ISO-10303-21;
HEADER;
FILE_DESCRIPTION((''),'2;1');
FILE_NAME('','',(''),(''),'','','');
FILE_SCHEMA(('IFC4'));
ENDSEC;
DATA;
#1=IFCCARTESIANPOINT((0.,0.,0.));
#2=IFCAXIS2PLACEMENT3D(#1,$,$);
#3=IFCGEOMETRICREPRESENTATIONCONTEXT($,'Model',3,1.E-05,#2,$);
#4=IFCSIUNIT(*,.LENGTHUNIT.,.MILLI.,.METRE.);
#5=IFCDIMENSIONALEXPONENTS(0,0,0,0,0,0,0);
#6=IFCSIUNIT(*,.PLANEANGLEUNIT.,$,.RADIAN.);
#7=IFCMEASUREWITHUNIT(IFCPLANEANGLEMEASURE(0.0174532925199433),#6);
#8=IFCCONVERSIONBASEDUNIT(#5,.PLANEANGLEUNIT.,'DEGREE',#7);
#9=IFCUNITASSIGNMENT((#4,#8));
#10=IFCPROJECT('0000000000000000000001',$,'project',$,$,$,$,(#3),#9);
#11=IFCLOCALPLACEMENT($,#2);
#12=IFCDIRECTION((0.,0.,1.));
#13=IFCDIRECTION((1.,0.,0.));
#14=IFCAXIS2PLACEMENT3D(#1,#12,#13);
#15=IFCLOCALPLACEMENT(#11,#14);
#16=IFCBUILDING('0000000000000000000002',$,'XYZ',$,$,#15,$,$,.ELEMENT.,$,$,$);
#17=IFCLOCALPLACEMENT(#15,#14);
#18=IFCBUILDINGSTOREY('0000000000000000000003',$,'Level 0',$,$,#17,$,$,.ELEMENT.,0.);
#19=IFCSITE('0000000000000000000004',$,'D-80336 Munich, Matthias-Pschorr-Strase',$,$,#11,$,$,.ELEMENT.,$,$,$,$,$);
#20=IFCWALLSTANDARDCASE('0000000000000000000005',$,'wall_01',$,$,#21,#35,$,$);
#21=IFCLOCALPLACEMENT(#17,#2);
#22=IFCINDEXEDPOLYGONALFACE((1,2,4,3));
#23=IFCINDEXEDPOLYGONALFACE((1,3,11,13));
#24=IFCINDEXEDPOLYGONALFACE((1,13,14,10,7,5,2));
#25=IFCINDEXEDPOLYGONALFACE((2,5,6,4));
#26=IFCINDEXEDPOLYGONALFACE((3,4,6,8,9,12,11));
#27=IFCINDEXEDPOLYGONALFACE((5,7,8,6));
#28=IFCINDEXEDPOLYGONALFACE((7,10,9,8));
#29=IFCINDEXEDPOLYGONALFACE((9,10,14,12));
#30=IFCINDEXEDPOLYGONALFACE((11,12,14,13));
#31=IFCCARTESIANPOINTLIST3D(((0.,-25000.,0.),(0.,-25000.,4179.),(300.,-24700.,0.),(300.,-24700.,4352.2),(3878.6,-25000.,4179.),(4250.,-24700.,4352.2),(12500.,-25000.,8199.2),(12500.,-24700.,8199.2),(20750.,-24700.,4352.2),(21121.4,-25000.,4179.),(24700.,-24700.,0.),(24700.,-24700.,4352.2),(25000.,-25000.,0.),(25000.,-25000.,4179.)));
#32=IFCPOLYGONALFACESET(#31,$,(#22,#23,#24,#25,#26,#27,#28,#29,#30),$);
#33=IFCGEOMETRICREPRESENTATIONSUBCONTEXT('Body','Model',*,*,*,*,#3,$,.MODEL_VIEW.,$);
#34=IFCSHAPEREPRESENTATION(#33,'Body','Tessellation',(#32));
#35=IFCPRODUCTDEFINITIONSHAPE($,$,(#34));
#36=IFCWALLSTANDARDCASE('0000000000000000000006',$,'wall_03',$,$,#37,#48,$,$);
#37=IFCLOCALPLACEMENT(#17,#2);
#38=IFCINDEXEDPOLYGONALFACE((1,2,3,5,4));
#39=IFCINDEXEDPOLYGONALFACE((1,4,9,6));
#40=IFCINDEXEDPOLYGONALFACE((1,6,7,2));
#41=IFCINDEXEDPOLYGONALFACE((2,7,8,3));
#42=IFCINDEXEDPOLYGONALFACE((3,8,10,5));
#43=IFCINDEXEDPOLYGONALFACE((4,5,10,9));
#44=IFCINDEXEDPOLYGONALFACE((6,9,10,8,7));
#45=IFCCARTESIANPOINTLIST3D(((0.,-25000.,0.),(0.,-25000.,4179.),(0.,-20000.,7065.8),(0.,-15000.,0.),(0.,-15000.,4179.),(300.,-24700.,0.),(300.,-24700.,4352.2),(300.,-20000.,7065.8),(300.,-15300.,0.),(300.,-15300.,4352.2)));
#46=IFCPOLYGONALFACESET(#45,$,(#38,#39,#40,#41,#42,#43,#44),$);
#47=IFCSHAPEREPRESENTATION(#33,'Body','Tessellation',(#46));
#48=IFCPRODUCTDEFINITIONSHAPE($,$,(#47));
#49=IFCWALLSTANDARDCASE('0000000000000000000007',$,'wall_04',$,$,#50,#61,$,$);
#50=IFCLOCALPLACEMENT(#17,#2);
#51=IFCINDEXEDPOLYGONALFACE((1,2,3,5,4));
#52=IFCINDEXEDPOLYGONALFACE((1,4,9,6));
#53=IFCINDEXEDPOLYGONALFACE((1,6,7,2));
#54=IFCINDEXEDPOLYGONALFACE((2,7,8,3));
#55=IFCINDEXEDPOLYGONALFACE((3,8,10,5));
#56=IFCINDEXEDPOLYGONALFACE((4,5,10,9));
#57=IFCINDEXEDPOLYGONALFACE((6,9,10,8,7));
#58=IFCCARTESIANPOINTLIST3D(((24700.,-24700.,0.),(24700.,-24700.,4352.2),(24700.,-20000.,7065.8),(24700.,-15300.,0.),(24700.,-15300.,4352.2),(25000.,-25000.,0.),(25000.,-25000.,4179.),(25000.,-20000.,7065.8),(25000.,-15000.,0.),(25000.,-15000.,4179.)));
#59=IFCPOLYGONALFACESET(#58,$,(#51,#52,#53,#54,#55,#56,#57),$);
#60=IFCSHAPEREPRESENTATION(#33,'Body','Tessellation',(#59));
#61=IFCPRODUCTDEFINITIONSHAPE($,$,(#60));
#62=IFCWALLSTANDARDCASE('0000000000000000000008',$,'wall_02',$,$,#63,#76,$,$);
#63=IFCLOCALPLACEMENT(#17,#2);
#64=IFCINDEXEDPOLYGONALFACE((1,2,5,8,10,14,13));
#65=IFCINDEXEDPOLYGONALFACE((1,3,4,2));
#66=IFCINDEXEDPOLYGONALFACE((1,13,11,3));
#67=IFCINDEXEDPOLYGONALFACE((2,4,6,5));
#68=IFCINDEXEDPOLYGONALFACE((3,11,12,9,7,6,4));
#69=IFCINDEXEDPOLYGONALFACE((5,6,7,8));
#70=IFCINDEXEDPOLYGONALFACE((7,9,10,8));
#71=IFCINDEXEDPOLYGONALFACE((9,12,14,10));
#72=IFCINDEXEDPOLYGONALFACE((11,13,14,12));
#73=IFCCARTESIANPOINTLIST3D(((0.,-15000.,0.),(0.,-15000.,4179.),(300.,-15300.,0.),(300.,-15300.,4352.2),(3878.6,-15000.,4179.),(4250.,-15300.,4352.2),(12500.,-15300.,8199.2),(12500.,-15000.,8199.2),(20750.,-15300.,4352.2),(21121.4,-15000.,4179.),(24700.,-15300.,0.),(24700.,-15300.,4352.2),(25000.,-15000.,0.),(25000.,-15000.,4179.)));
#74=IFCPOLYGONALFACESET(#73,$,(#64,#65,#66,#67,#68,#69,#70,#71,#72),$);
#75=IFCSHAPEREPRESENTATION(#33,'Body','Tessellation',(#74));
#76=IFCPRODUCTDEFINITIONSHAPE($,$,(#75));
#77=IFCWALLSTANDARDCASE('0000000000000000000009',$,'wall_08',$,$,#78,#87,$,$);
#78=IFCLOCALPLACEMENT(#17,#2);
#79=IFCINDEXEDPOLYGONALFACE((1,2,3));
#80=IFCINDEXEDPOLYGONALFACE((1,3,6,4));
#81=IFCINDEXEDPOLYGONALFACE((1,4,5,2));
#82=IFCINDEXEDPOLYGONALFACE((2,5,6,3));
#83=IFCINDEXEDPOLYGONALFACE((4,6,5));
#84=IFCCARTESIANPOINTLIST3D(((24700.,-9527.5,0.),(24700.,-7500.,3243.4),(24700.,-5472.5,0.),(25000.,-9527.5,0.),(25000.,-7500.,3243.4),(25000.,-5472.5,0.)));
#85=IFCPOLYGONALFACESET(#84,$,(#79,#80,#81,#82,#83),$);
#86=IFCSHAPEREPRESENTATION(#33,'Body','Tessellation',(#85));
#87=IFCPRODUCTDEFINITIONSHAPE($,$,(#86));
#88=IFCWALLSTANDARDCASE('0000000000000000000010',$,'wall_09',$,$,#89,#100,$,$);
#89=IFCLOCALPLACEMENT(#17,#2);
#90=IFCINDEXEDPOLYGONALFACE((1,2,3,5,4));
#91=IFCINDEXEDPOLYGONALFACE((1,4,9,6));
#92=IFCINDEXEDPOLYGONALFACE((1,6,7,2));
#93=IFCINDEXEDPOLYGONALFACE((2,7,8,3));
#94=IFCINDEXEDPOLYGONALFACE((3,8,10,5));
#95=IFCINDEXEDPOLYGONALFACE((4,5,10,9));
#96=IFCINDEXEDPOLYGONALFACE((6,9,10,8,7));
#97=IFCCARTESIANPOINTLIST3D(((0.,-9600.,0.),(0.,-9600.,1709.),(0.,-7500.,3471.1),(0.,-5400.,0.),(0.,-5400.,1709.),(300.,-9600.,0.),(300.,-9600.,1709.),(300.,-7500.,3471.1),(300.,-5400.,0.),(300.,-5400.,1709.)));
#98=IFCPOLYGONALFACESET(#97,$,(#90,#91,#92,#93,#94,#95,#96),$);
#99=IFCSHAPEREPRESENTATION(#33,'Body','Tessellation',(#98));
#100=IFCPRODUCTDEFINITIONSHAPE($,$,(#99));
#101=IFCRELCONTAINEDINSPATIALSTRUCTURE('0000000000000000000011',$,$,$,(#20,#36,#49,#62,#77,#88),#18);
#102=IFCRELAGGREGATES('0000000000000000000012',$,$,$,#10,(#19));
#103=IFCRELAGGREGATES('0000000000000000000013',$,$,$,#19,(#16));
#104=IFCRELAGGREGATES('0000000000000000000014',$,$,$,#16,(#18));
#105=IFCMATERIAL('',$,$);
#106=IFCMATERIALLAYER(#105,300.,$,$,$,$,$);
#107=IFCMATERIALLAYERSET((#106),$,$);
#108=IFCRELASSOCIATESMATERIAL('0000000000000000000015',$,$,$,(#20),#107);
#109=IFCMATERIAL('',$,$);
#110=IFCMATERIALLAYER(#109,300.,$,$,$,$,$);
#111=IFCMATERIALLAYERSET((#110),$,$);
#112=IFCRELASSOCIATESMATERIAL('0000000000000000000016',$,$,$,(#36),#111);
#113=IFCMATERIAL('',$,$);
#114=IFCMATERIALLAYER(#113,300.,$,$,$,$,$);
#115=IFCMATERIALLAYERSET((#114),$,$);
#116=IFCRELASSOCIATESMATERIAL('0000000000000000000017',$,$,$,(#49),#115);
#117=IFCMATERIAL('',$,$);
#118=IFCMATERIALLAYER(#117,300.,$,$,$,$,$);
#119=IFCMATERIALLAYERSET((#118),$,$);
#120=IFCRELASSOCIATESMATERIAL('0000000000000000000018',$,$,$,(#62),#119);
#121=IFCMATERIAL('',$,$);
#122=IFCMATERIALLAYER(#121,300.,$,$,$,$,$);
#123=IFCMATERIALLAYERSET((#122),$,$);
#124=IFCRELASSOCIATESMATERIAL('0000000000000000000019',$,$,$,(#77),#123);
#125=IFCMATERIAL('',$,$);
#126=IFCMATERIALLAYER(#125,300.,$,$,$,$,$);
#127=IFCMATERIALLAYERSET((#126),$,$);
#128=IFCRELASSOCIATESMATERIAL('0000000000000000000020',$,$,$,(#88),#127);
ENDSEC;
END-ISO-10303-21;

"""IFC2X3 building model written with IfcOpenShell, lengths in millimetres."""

from ifc_helpers import new_model, entity, si_unit, converted_unit, frame, frame_2d, origin, origin_with_axes, place, context, subcontext, project, spatial, polyline, rectangle, outline, extrude, clip, bounded_halfspace, material, layer, layer_set, layer_usage, element, save


model = new_model("IFC2X3")

# Units and contexts
model_context = context("Model", 3, precision=1e-05, world=origin())
body_context = subcontext(model_context, "Body", "Model", "MODEL_VIEW")
ifc_project = project(units=[si_unit("LENGTHUNIT", "METRE", prefix="MILLI"), converted_unit("PLANEANGLEUNIT", "DEGREE", entity("IfcPlaneAngleMeasure", 0.0174532925199433), si_unit("PLANEANGLEUNIT", "RADIAN"), dimensions=[0, 0, 0, 0, 0, 0, 0])], contexts=[model_context])

# Site, building, storey
site_placement = place(None, origin())
site = spatial("IfcSite", under=ifc_project, at=site_placement, Name="D-80336 Munich, Matthias-Pschorr-Strase", CompositionType="ELEMENT")
building_placement = place(site_placement, origin_with_axes())
building = spatial("IfcBuilding", under=site, at=building_placement, Name="XYZ", CompositionType="ELEMENT")
storey_placement = place(building_placement, origin_with_axes())
storey = spatial("IfcBuildingStorey", under=building, at=storey_placement, Name="Level 0", CompositionType="ELEMENT", Elevation=0.0)

# Walls
ifc_material_1 = material(Name="")
ifc_layer_1 = layer(ifc_material_1, 300.0)
ifc_layer_set_1 = layer_set([ifc_layer_1])
ifc_layer_usage_1 = layer_usage(ifc_layer_set_1, "AXIS2", "POSITIVE", 0.0)
wall_1_placement = place(storey_placement, frame((0.0, -25000.0, 0.0), z_axis=(0.0, 0.0, 1.0), x_axis=(1.0, 0.0, 0.0)))
element("IfcWallStandardCase", 1, at=wall_1_placement, inside=storey, material=ifc_layer_usage_1, Name="wall_01", context=body_context, shape_type="Clipping", body=[
    clip(clip(clip(clip(extrude(outline(polyline([(0.0, 0.0), (25000.0, 0.0), (24700.0, 300.0), (300.0, 300.0), (0.0, 0.0)])), origin_with_axes(), (0.0, 0.0, 1.0), 8199.2), bounded_halfspace(frame((4250.0, 300.0, 4352.2), z_axis=(0.422618, 0.0, -0.906308), x_axis=(-0.731317, -0.590662, -0.341019)), True, origin(), polyline([(4250.0, 300.0), (3878.6, 0.0), (12500.0, 0.0), (12500.0, 300.0), (4250.0, 300.0)]))), bounded_halfspace(frame((20750.0, 300.0, 4352.2), z_axis=(-0.422618, 0.0, -0.906308), x_axis=(-0.906308, 0.0, 0.422618)), True, origin(), polyline([(20750.0, 300.0), (12500.0, 300.0), (12500.0, 0.0), (21121.4, 0.0), (20750.0, 300.0)]))), bounded_halfspace(frame((3878.6, 0.0, 4179.0), z_axis=(0.0, 0.5, -0.866025), x_axis=(0.731317, 0.590662, 0.341019)), True, origin(), polyline([(3878.6, 0.0), (4250.0, 300.0), (300.0, 300.0), (0.0, 0.0), (3878.6, 0.0)]))), bounded_halfspace(frame((24700.0, 300.0, 4352.2), z_axis=(0.0, 0.5, -0.866025), x_axis=(-1.0, 0.0, 0.0)), True, origin(), polyline([(24700.0, 300.0), (20750.0, 300.0), (21121.4, 0.0), (25000.0, 0.0), (24700.0, 300.0)]))),
])
ifc_material_2 = material(Name="")
ifc_layer_2 = layer(ifc_material_2, 300.0)
ifc_layer_set_2 = layer_set([ifc_layer_2])
ifc_layer_usage_2 = layer_usage(ifc_layer_set_2, "AXIS2", "POSITIVE", 0.0)
wall_2_placement = place(storey_placement, frame((0.0, -15000.0, 0.0), z_axis=(0.0, 0.0, 1.0), x_axis=(0.0, -1.0, 0.0)))
element("IfcWallStandardCase", 2, at=wall_2_placement, inside=storey, material=ifc_layer_usage_2, Name="wall_03", context=body_context, shape_type="Clipping", body=[
    clip(clip(extrude(outline(polyline([(0.0, 0.0), (10000.0, 0.0), (9700.0, 300.0), (300.0, 300.0), (0.0, 0.0)])), origin_with_axes(), (0.0, 0.0, 1.0), 7065.8), bounded_halfspace(frame((9700.0, 300.0, 4352.2), z_axis=(-0.5, 0.0, -0.866025), x_axis=(-0.866025, 0.0, 0.5)), True, origin(), polyline([(9700.0, 300.0), (5000.0, 300.0), (5000.0, 0.0), (10000.0, 0.0), (9700.0, 300.0)]))), bounded_halfspace(frame((0.0, 0.0, 4179.0), z_axis=(0.5, 0.0, -0.866025), x_axis=(0.866025, 0.0, 0.5)), True, origin(), polyline([(0.0, 0.0), (5000.0, 0.0), (5000.0, 300.0), (300.0, 300.0), (0.0, 0.0)]))),
])
ifc_material_3 = material(Name="")
ifc_layer_3 = layer(ifc_material_3, 300.0)
ifc_layer_set_3 = layer_set([ifc_layer_3])
ifc_layer_usage_3 = layer_usage(ifc_layer_set_3, "AXIS2", "POSITIVE", 0.0)
wall_3_placement = place(storey_placement, frame((24700.0, -15300.0, 0.0), z_axis=(0.0, 0.0, 1.0), x_axis=(0.0, -1.0, 0.0)))
element("IfcWallStandardCase", 3, at=wall_3_placement, inside=storey, material=ifc_layer_usage_3, Name="wall_04", context=body_context, shape_type="Clipping", body=[
    clip(clip(extrude(outline(polyline([(0.0, 0.0), (9400.0, 0.0), (9700.0, 300.0), (-300.0, 300.0), (0.0, 0.0)])), origin_with_axes(), (0.0, 0.0, 1.0), 7065.8), bounded_halfspace(frame((0.0, 0.0, 4352.2), z_axis=(0.5, 0.0, -0.866025), x_axis=(0.866025, 0.0, 0.5)), True, origin(), polyline([(0.0, 0.0), (4700.0, 0.0), (4700.0, 300.0), (-300.0, 300.0), (0.0, 0.0)]))), bounded_halfspace(frame((9700.0, 300.0, 4179.0), z_axis=(-0.5, 0.0, -0.866025), x_axis=(-0.866025, 0.0, 0.5)), True, origin(), polyline([(9700.0, 300.0), (4700.0, 300.0), (4700.0, 0.0), (9400.0, 0.0), (9700.0, 300.0)]))),
])
ifc_material_4 = material(Name="")
ifc_layer_4 = layer(ifc_material_4, 300.0)
ifc_layer_set_4 = layer_set([ifc_layer_4])
ifc_layer_usage_4 = layer_usage(ifc_layer_set_4, "AXIS2", "POSITIVE", 0.0)
wall_4_placement = place(storey_placement, frame((25000.0, -15000.0, 0.0), z_axis=(0.0, 0.0, 1.0), x_axis=(-1.0, 0.0, 0.0)))
element("IfcWallStandardCase", 4, at=wall_4_placement, inside=storey, material=ifc_layer_usage_4, Name="wall_02", context=body_context, shape_type="Clipping", body=[
    clip(clip(clip(clip(extrude(outline(polyline([(0.0, 0.0), (25000.0, 0.0), (24700.0, 300.0), (300.0, 300.0), (0.0, 0.0)])), origin_with_axes(), (0.0, 0.0, 1.0), 8199.2), bounded_halfspace(frame((3878.6, 0.0, 4179.0), z_axis=(0.0, 0.5, -0.866025), x_axis=(0.731317, 0.590662, 0.341019)), True, origin(), polyline([(3878.6, 0.0), (4250.0, 300.0), (300.0, 300.0), (0.0, 0.0), (3878.6, 0.0)]))), bounded_halfspace(frame((21121.4, 0.0, 4179.0), z_axis=(-0.422618, 0.0, -0.906308), x_axis=(-0.731317, 0.590662, 0.341019)), True, origin(), polyline([(21121.4, 0.0), (20750.0, 300.0), (12500.0, 300.0), (12500.0, 0.0), (21121.4, 0.0)]))), bounded_halfspace(frame((24700.0, 300.0, 4352.2), z_axis=(0.0, 0.5, -0.866025), x_axis=(-1.0, 0.0, 0.0)), True, origin(), polyline([(24700.0, 300.0), (20750.0, 300.0), (21121.4, 0.0), (25000.0, 0.0), (24700.0, 300.0)]))), bounded_halfspace(frame((3878.6, 0.0, 4179.0), z_axis=(0.422618, 0.0, -0.906308), x_axis=(0.906308, 0.0, 0.422618)), True, origin(), polyline([(3878.6, 0.0), (12500.0, 0.0), (12500.0, 300.0), (4250.0, 300.0), (3878.6, 0.0)]))),
])
ifc_material_5 = material(Name="")
ifc_layer_5 = layer(ifc_material_5, 300.0)
ifc_layer_set_5 = layer_set([ifc_layer_5])
ifc_layer_usage_5 = layer_usage(ifc_layer_set_5, "AXIS2", "POSITIVE", 0.0)
wall_5_placement = place(storey_placement, frame((25000.0, -9527.5, 0.0), z_axis=(0.0, 0.0, 1.0), x_axis=(0.0, 1.0, 0.0)))
element("IfcWallStandardCase", 5, at=wall_5_placement, inside=storey, material=ifc_layer_usage_5, Name="wall_08", context=body_context, shape_type="Clipping", body=[
    clip(clip(extrude(outline(polyline([(0.0, 0.0), (4055.0, 0.0), (4055.0, 300.0), (0.0, 300.0), (0.0, 0.0)])), origin_with_axes(), (0.0, 0.0, 1.0), 3243.4), bounded_halfspace(frame((2027.5, 300.0, 3243.4), z_axis=(0.847956, 0.0, -0.530067), x_axis=(-0.530067, 0.0, -0.847956)), True, origin(), polyline([(2027.5, 300.0), (0.0, 300.0), (0.0, 0.0), (2027.5, 0.0), (2027.5, 300.0)]))), bounded_halfspace(frame((2027.5, 300.0, 3243.4), z_axis=(-0.847956, 0.0, -0.530067), x_axis=(0.0, -1.0, 0.0)), True, origin(), polyline([(2027.5, 300.0), (2027.5, 0.0), (4055.0, 0.0), (4055.0, 300.0), (2027.5, 300.0)]))),
])
ifc_material_6 = material(Name="")
ifc_layer_6 = layer(ifc_material_6, 300.0)
ifc_layer_set_6 = layer_set([ifc_layer_6])
ifc_layer_usage_6 = layer_usage(ifc_layer_set_6, "AXIS2", "POSITIVE", 0.0)
wall_6_placement = place(storey_placement, frame((0.0, -5400.0, 0.0), z_axis=(0.0, 0.0, 1.0), x_axis=(0.0, -1.0, 0.0)))
element("IfcWallStandardCase", 6, at=wall_6_placement, inside=storey, material=ifc_layer_usage_6, Name="wall_09", context=body_context, shape_type="Clipping", body=[
    clip(clip(extrude(rectangle(XDim=4200.0, YDim=300.0, at=frame_2d((2100.0, 150.0), x_axis=(1.0, 0.0))), origin_with_axes(), (0.0, 0.0, 1.0), 3471.1), bounded_halfspace(frame((2100.0, 300.0, 3471.1), z_axis=(0.642788, 0.0, -0.766044), x_axis=(-0.766044, 0.0, -0.642788)), True, origin(), polyline([(2100.0, 300.0), (0.0, 300.0), (0.0, 0.0), (2100.0, 0.0), (2100.0, 300.0)]))), bounded_halfspace(frame((2100.0, 300.0, 3471.1), z_axis=(-0.642788, 0.0, -0.766044), x_axis=(0.0, -1.0, 0.0)), True, origin(), polyline([(2100.0, 300.0), (2100.0, 0.0), (4200.0, 0.0), (4200.0, 300.0), (2100.0, 300.0)]))),
])

save(model, "model.ifc")
